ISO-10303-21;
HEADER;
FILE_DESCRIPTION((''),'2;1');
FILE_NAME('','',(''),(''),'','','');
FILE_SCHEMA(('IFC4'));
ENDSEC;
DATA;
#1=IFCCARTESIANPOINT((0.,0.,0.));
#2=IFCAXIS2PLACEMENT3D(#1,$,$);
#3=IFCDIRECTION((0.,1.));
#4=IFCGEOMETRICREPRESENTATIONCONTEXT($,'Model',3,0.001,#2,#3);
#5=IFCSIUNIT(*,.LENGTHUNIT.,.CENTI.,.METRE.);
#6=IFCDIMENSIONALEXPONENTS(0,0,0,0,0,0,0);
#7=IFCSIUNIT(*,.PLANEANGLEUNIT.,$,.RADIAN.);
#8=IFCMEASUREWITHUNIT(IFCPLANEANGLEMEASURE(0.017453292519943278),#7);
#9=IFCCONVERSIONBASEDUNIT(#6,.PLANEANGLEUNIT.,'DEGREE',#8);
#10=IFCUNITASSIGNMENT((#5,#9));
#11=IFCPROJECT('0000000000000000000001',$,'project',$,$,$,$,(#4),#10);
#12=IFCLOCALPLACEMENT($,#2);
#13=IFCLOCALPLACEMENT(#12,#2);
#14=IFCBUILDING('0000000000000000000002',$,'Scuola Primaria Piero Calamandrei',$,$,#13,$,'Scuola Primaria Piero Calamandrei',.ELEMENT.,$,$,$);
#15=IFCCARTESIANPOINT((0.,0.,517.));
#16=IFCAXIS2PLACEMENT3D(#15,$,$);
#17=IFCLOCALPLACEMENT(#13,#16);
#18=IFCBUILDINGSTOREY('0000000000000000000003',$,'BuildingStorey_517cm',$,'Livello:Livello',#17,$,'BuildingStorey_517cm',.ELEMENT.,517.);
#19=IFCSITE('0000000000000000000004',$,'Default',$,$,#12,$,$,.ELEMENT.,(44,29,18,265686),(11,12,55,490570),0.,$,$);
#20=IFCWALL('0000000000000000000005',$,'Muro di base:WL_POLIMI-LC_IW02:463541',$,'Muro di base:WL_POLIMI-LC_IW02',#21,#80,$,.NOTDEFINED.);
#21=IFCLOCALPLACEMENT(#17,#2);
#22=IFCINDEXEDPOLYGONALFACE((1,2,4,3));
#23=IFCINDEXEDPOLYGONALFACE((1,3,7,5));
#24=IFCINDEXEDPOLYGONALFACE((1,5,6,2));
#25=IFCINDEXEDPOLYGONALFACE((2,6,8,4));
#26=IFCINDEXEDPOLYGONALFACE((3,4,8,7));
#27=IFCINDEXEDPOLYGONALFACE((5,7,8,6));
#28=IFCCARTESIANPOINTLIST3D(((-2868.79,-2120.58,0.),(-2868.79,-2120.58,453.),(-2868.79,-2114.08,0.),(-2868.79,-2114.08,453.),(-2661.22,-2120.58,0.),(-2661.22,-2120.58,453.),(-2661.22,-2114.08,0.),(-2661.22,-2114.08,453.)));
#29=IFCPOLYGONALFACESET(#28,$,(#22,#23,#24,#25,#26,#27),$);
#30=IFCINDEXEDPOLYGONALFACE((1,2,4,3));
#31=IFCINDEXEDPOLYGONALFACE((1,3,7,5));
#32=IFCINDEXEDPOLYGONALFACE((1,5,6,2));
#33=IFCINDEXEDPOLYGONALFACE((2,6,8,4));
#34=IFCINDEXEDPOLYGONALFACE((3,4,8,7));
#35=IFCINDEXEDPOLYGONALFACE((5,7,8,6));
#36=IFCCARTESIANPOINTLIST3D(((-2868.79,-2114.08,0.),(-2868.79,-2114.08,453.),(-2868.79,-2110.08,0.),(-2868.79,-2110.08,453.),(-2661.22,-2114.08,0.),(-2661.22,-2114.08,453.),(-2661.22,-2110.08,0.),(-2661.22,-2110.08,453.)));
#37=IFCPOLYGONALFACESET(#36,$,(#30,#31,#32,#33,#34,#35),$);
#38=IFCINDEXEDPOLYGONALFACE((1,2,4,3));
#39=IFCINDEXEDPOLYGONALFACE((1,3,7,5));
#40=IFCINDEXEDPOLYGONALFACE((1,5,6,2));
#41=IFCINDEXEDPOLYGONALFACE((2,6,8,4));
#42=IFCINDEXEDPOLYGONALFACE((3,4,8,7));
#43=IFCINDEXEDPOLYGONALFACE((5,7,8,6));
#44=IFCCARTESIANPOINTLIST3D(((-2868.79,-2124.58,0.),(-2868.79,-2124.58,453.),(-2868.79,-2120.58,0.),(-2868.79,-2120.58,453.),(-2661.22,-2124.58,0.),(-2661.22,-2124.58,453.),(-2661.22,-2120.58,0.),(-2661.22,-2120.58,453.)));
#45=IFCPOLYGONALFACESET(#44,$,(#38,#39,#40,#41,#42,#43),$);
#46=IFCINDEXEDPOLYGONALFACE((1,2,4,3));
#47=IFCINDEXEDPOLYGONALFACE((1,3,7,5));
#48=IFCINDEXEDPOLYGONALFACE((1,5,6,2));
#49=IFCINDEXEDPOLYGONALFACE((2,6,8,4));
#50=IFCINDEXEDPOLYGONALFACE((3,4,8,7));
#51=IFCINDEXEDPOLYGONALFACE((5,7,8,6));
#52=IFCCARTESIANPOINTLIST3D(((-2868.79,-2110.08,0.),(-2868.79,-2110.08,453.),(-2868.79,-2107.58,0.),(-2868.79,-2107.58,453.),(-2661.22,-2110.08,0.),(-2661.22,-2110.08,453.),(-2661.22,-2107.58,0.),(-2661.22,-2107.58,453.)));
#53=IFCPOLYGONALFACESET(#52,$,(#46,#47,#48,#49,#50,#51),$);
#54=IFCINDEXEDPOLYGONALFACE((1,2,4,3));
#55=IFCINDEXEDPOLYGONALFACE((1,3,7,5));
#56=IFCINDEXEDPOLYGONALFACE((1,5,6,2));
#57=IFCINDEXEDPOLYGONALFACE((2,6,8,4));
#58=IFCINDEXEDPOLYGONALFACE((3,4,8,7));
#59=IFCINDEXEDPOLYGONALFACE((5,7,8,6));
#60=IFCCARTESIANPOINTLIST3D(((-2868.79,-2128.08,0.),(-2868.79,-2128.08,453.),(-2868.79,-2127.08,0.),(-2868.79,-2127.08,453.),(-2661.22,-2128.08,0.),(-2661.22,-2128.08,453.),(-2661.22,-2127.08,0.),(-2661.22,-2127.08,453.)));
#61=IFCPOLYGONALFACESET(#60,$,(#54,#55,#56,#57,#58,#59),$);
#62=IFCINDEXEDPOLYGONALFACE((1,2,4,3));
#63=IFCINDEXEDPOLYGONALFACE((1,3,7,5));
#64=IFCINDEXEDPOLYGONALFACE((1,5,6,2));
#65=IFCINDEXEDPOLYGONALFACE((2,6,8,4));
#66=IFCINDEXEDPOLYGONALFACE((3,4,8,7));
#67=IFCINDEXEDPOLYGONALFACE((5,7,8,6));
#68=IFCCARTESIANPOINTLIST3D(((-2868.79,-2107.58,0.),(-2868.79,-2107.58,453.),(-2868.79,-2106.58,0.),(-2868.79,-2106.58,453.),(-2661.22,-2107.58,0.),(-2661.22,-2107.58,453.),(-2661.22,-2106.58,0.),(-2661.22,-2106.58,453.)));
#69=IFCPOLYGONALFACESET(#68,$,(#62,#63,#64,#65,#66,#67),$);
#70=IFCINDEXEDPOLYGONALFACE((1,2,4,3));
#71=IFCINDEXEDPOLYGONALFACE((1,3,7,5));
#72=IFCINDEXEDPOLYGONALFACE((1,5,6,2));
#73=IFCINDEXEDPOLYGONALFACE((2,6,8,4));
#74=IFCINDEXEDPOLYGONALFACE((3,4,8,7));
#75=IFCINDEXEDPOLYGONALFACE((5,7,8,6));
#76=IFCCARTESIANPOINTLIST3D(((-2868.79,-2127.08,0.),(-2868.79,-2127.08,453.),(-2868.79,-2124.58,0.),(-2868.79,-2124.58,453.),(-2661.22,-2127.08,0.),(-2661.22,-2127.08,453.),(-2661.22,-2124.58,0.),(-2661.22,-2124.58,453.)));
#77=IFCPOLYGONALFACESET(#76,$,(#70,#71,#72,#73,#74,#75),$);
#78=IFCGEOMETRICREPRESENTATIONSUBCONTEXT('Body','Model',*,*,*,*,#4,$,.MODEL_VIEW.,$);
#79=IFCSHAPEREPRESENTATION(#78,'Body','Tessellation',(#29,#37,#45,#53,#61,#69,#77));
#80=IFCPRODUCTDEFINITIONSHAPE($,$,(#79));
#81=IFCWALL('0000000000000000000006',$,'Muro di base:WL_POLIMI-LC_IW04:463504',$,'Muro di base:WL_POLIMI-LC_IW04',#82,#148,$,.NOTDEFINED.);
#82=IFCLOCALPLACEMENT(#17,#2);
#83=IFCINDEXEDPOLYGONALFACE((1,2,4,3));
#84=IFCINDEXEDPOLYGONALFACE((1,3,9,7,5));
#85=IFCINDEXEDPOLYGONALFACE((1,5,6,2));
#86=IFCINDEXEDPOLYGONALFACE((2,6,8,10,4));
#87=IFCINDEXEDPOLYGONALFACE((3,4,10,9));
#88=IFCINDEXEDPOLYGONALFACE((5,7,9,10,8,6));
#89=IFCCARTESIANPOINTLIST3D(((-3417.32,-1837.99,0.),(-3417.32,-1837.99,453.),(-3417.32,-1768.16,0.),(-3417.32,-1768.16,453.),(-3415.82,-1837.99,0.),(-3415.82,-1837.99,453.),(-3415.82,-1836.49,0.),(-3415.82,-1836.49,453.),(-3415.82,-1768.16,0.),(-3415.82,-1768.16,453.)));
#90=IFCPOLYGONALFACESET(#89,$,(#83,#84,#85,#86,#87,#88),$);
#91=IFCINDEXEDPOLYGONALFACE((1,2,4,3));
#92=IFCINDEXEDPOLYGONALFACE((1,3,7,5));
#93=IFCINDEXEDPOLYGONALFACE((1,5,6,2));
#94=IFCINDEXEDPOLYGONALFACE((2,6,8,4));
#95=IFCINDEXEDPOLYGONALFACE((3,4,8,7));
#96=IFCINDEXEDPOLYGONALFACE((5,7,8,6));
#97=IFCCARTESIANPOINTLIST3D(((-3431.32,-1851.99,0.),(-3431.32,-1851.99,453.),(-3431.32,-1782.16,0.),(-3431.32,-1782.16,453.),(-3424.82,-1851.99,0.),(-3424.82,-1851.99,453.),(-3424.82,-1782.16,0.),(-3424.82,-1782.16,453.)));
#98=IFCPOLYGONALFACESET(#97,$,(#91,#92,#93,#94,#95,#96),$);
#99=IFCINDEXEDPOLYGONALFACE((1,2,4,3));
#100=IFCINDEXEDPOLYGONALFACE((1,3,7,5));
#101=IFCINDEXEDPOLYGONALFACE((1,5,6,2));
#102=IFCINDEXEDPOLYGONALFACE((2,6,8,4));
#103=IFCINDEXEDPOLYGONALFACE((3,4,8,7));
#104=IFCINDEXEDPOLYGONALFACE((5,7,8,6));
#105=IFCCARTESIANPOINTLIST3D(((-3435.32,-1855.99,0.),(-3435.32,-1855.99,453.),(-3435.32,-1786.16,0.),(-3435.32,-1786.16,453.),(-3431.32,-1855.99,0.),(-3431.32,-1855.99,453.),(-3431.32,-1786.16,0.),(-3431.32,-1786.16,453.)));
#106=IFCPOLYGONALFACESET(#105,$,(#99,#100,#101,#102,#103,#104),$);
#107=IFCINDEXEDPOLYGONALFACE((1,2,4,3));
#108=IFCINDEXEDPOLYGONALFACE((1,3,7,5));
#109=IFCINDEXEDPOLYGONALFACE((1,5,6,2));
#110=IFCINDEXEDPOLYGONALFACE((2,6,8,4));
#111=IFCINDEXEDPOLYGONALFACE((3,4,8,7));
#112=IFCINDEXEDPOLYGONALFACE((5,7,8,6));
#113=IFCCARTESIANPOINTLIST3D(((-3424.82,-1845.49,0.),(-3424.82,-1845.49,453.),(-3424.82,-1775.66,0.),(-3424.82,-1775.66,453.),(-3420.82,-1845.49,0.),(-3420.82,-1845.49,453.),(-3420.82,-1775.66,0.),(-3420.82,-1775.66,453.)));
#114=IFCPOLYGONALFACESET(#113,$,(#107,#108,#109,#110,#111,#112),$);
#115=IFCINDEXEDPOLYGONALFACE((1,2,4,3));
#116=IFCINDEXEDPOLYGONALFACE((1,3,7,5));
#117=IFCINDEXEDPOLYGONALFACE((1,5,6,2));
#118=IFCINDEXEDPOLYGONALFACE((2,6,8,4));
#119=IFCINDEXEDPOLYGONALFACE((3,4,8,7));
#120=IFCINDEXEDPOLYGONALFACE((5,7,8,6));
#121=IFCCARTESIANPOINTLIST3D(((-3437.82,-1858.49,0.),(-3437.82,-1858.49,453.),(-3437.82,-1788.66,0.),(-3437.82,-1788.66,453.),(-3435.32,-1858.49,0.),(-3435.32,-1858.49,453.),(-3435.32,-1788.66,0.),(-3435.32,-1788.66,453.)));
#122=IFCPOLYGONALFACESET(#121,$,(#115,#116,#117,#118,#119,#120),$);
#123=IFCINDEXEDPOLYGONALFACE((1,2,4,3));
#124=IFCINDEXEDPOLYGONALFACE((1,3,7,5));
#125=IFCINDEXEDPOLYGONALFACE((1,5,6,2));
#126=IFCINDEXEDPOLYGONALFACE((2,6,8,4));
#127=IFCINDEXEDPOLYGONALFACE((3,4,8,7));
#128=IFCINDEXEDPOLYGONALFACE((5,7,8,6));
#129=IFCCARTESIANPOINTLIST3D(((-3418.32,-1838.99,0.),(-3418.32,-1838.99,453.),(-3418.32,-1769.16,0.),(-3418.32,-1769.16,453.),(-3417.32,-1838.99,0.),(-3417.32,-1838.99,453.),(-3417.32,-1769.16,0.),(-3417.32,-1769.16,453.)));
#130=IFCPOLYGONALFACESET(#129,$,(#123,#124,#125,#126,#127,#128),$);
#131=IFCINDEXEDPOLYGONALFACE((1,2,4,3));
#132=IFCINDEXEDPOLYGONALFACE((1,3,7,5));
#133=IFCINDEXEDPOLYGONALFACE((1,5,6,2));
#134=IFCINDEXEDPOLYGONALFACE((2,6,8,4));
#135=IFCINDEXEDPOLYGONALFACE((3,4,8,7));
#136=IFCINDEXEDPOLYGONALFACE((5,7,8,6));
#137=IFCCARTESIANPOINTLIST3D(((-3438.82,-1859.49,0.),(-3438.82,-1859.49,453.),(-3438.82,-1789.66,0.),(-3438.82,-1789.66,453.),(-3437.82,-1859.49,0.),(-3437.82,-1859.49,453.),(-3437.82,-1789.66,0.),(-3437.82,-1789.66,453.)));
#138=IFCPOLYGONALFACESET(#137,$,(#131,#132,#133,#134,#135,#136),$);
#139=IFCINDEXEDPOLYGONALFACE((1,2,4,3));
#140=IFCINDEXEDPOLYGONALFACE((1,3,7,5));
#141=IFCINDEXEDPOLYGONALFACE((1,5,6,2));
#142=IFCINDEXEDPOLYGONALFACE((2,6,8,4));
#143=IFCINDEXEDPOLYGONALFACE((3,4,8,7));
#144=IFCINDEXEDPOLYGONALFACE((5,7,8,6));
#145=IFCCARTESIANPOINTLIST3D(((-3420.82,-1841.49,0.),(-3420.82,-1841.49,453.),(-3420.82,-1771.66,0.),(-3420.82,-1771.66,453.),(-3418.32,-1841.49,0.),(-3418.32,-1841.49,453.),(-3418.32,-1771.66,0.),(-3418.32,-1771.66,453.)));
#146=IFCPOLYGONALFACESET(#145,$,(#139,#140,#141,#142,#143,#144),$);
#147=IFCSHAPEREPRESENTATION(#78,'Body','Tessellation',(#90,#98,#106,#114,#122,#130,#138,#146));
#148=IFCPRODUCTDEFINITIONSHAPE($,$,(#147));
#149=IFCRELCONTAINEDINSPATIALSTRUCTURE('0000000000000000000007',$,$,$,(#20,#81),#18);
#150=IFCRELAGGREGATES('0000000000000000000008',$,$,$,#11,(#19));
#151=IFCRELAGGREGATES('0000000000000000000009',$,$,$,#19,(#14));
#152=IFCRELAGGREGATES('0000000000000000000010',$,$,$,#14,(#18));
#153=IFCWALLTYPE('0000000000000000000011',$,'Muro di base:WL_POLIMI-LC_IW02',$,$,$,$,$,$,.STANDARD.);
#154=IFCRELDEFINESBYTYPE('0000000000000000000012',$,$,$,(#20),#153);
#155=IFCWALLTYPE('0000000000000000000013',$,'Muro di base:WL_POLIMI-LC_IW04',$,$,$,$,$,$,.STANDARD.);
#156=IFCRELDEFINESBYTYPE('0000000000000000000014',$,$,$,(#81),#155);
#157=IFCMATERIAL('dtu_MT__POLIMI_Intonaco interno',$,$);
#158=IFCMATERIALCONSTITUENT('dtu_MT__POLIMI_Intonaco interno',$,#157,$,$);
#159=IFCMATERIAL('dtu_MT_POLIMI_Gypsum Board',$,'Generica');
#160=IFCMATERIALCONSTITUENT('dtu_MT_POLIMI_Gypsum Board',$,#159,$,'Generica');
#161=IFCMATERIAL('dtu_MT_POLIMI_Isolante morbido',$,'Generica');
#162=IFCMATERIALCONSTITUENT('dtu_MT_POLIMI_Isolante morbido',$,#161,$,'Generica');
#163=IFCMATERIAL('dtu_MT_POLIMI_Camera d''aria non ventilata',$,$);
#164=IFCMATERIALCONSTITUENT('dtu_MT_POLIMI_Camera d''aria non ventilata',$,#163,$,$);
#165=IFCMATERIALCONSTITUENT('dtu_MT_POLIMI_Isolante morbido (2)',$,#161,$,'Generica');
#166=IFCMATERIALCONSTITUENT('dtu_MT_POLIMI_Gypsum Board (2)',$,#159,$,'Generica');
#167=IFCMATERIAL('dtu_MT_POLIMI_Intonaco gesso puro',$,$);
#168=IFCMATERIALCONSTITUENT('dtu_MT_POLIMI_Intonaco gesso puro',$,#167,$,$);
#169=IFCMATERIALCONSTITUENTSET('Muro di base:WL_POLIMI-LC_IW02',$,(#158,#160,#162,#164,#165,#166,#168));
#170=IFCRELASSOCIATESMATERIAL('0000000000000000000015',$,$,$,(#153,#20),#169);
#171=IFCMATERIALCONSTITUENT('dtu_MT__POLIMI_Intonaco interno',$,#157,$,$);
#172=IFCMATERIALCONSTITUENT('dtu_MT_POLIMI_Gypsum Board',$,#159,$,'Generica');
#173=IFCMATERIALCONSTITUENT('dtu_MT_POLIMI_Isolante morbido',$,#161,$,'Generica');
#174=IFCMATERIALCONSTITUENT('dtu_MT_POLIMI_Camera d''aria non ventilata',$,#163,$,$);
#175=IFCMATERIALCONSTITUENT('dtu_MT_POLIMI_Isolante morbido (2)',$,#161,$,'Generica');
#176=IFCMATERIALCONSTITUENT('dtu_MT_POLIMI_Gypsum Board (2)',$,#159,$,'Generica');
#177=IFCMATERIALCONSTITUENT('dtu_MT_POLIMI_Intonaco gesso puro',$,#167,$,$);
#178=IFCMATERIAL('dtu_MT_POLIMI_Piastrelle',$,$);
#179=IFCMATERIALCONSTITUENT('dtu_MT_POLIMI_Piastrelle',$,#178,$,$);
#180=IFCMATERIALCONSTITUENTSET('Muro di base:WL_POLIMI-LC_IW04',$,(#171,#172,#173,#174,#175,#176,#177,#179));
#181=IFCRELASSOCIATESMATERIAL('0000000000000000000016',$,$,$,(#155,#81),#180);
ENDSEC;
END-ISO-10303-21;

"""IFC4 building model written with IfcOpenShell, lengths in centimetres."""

from ifc_helpers import new_model, entity, si_unit, converted_unit, direction, frame, origin, place, context, subcontext, project, spatial, indexed_curve, outline, extrude, material, constituent, constituent_set, type_object, element, save


model = new_model("IFC4")

# Units and contexts
model_context = context("Model", 3, precision=0.001, world=origin(), true_north=direction((0.0, 1.0)))
body_context = subcontext(model_context, "Body", "Model", "MODEL_VIEW")
ifc_project = project(units=[si_unit("LENGTHUNIT", "METRE", prefix="CENTI"), converted_unit("PLANEANGLEUNIT", "DEGREE", entity("IfcPlaneAngleMeasure", 0.017453292519943278), si_unit("PLANEANGLEUNIT", "RADIAN"), dimensions=[0, 0, 0, 0, 0, 0, 0])], contexts=[model_context])

# Site, building, storey
site_placement = place(None, origin())
site = spatial("IfcSite", under=ifc_project, at=site_placement, Name="Default", CompositionType="ELEMENT", RefLatitude=(44, 29, 18, 265686), RefLongitude=(11, 12, 55, 490570), RefElevation=0.0)
building_placement = place(site_placement, origin())
building = spatial("IfcBuilding", under=site, at=building_placement, Name="Scuola Primaria Piero Calamandrei", LongName="Scuola Primaria Piero Calamandrei", CompositionType="ELEMENT")
storey_placement = place(building_placement, frame((0.0, 0.0, 517.0)))
storey = spatial("IfcBuildingStorey", under=building, at=storey_placement, Name="BuildingStorey_517cm", ObjectType="Livello:Livello", LongName="BuildingStorey_517cm", CompositionType="ELEMENT", Elevation=517.0)

# Shared definitions
ifc_material_1 = material(Name="dtu_MT_POLIMI_Isolante morbido", Category="Generica")
ifc_material_2 = material(Name="dtu_MT_POLIMI_Gypsum Board", Category="Generica")
ifc_material_3 = material(Name="dtu_MT__POLIMI_Intonaco interno")

# Shared definitions
ifc_constituent_1 = constituent(ifc_material_3, Name="dtu_MT__POLIMI_Intonaco interno")
ifc_constituent_2 = constituent(ifc_material_2, Name="dtu_MT_POLIMI_Gypsum Board", Category="Generica")
ifc_constituent_3 = constituent(ifc_material_1, Name="dtu_MT_POLIMI_Isolante morbido", Category="Generica")
ifc_material_4 = material(Name="dtu_MT_POLIMI_Camera d'aria non ventilata")
ifc_constituent_4 = constituent(ifc_material_4, Name="dtu_MT_POLIMI_Camera d'aria non ventilata")
ifc_constituent_5 = constituent(ifc_material_1, Name="dtu_MT_POLIMI_Isolante morbido (2)", Category="Generica")
ifc_constituent_6 = constituent(ifc_material_2, Name="dtu_MT_POLIMI_Gypsum Board (2)", Category="Generica")
ifc_material_5 = material(Name="dtu_MT_POLIMI_Intonaco gesso puro")
ifc_constituent_7 = constituent(ifc_material_5, Name="dtu_MT_POLIMI_Intonaco gesso puro")
ifc_constituent_set_1 = constituent_set(constituents=[ifc_constituent_1, ifc_constituent_2, ifc_constituent_3, ifc_constituent_4, ifc_constituent_5, ifc_constituent_6, ifc_constituent_7], Name="Muro di base:WL_POLIMI-LC_IW02")
wall_type_1 = type_object("IfcWallType", Name="Muro di base:WL_POLIMI-LC_IW02", PredefinedType="STANDARD", material=ifc_constituent_set_1)

# Walls
wall_1_placement = place(storey_placement, frame((-2868.79, -2117.33, 0.0)))
element("IfcWall", 1, at=wall_1_placement, inside=storey, type_object=wall_type_1, material=ifc_constituent_set_1, Name="Muro di base:WL_POLIMI-LC_IW02:463541", ObjectType="Muro di base:WL_POLIMI-LC_IW02", PredefinedType="NOTDEFINED", context=body_context, shape_type="SweptSolid", body=[
    extrude(outline(indexed_curve([(-103.79, -3.25), (103.79, -3.25), (103.79, 3.25), (-103.79, 3.25), (-103.79, -3.25)], self_intersect=False)), frame((103.79, 0.0, 0.0)), (0.0, 0.0, 1.0), 453.0),
    extrude(outline(indexed_curve([(-103.79, -2.0), (103.79, -2.0), (103.79, 2.0), (-103.79, 2.0), (-103.79, -2.0)], self_intersect=False)), frame((103.79, 5.25, 0.0)), (0.0, 0.0, 1.0), 453.0),
    extrude(outline(indexed_curve([(-103.79, -2.0), (103.79, -2.0), (103.79, 2.0), (-103.79, 2.0), (-103.79, -2.0)], self_intersect=False)), frame((103.79, -5.25, 0.0)), (0.0, 0.0, 1.0), 453.0),
    extrude(outline(indexed_curve([(-103.79, -1.25), (103.79, -1.25), (103.79, 1.25), (-103.79, 1.25), (-103.79, -1.25)], self_intersect=False)), frame((103.79, 8.5, 0.0)), (0.0, 0.0, 1.0), 453.0),
    extrude(outline(indexed_curve([(-0.5, -103.79), (0.5, -103.79), (0.5, 103.79), (-0.5, 103.79), (-0.5, -103.79)], self_intersect=False)), frame((103.79, -10.25, 0.0), z_axis=(0.0, 0.0, 1.0), x_axis=(0.0, 1.0, 0.0)), (0.0, 0.0, 1.0), 453.0),
    extrude(outline(indexed_curve([(-0.5, -103.79), (0.5, -103.79), (0.5, 103.79), (-0.5, 103.79), (-0.5, -103.79)], self_intersect=False)), frame((103.79, 10.25, 0.0), z_axis=(0.0, 0.0, 1.0), x_axis=(0.0, -1.0, 0.0)), (0.0, 0.0, 1.0), 453.0),
    extrude(outline(indexed_curve([(-103.79, -1.25), (103.79, -1.25), (103.79, 1.25), (-103.79, 1.25), (-103.79, -1.25)], self_intersect=False)), frame((103.79, -8.5, 0.0)), (0.0, 0.0, 1.0), 453.0),
])
ifc_constituent_8 = constituent(ifc_material_3, Name="dtu_MT__POLIMI_Intonaco interno")
ifc_constituent_9 = constituent(ifc_material_2, Name="dtu_MT_POLIMI_Gypsum Board", Category="Generica")
ifc_constituent_10 = constituent(ifc_material_1, Name="dtu_MT_POLIMI_Isolante morbido", Category="Generica")
ifc_constituent_11 = constituent(ifc_material_4, Name="dtu_MT_POLIMI_Camera d'aria non ventilata")
ifc_constituent_12 = constituent(ifc_material_1, Name="dtu_MT_POLIMI_Isolante morbido (2)", Category="Generica")
ifc_constituent_13 = constituent(ifc_material_2, Name="dtu_MT_POLIMI_Gypsum Board (2)", Category="Generica")
ifc_constituent_14 = constituent(ifc_material_5, Name="dtu_MT_POLIMI_Intonaco gesso puro")
ifc_material_6 = material(Name="dtu_MT_POLIMI_Piastrelle")
ifc_constituent_15 = constituent(ifc_material_6, Name="dtu_MT_POLIMI_Piastrelle")
ifc_constituent_set_2 = constituent_set(constituents=[ifc_constituent_8, ifc_constituent_9, ifc_constituent_10, ifc_constituent_11, ifc_constituent_12, ifc_constituent_13, ifc_constituent_14, ifc_constituent_15], Name="Muro di base:WL_POLIMI-LC_IW04")
wall_type_2 = type_object("IfcWallType", Name="Muro di base:WL_POLIMI-LC_IW04", PredefinedType="STANDARD", material=ifc_constituent_set_2)
wall_2_placement = place(storey_placement, frame((-3427.32, -1859.49, 0.0), z_axis=(0.0, 0.0, 1.0), x_axis=(0.0, 1.0, 0.0)))
element("IfcWall", 2, at=wall_2_placement, inside=storey, type_object=wall_type_2, material=ifc_constituent_set_2, Name="Muro di base:WL_POLIMI-LC_IW04:463504", ObjectType="Muro di base:WL_POLIMI-LC_IW04", PredefinedType="NOTDEFINED", context=body_context, shape_type="SweptSolid", body=[
    extrude(outline(indexed_curve([(-26.73, -0.6), (41.6, -0.6), (41.6, 0.9), (-28.23, 0.9), (-28.23, -0.6), (-26.73, -0.6)], self_intersect=False)), frame((49.73, -10.9, 0.0)), (0.0, 0.0, 1.0), 453.0),
    extrude(outline(indexed_curve([(-34.91, -3.25), (34.91, -3.25), (34.91, 3.25), (-34.91, 3.25), (-34.91, -3.25)], self_intersect=False)), frame((42.41, 0.75, 0.0)), (0.0, 0.0, 1.0), 453.0),
    extrude(outline(indexed_curve([(-34.91, -2.0), (34.91, -2.0), (34.91, 2.0), (-34.91, 2.0), (-34.91, -2.0)], self_intersect=False)), frame((38.41, 6.0, 0.0)), (0.0, 0.0, 1.0), 453.0),
    extrude(outline(indexed_curve([(-34.91, -2.0), (34.91, -2.0), (34.91, 2.0), (-34.91, 2.0), (-34.91, -2.0)], self_intersect=False)), frame((48.91, -4.5, 0.0)), (0.0, 0.0, 1.0), 453.0),
    extrude(outline(indexed_curve([(-34.91, -1.25), (34.91, -1.25), (34.91, 1.25), (-34.91, 1.25), (-34.91, -1.25)], self_intersect=False)), frame((35.91, 9.25, 0.0)), (0.0, 0.0, 1.0), 453.0),
    extrude(outline(indexed_curve([(-34.91, -0.5), (34.91, -0.5), (34.91, 0.5), (-34.91, 0.5), (-34.91, -0.5)], self_intersect=False)), frame((55.41, -9.5, 0.0)), (0.0, 0.0, 1.0), 453.0),
    extrude(outline(indexed_curve([(-0.5, -34.91), (0.5, -34.91), (0.5, 34.91), (-0.5, 34.91), (-0.5, -34.91)], self_intersect=False)), frame((34.91, 11.0, 0.0), z_axis=(0.0, 0.0, 1.0), x_axis=(0.0, -1.0, 0.0)), (0.0, 0.0, 1.0), 453.0),
    extrude(outline(indexed_curve([(-34.91, -1.25), (34.91, -1.25), (34.91, 1.25), (-34.91, 1.25), (-34.91, -1.25)], self_intersect=False)), frame((52.91, -7.75, 0.0)), (0.0, 0.0, 1.0), 453.0),
])

save(model, "model.ifc")
